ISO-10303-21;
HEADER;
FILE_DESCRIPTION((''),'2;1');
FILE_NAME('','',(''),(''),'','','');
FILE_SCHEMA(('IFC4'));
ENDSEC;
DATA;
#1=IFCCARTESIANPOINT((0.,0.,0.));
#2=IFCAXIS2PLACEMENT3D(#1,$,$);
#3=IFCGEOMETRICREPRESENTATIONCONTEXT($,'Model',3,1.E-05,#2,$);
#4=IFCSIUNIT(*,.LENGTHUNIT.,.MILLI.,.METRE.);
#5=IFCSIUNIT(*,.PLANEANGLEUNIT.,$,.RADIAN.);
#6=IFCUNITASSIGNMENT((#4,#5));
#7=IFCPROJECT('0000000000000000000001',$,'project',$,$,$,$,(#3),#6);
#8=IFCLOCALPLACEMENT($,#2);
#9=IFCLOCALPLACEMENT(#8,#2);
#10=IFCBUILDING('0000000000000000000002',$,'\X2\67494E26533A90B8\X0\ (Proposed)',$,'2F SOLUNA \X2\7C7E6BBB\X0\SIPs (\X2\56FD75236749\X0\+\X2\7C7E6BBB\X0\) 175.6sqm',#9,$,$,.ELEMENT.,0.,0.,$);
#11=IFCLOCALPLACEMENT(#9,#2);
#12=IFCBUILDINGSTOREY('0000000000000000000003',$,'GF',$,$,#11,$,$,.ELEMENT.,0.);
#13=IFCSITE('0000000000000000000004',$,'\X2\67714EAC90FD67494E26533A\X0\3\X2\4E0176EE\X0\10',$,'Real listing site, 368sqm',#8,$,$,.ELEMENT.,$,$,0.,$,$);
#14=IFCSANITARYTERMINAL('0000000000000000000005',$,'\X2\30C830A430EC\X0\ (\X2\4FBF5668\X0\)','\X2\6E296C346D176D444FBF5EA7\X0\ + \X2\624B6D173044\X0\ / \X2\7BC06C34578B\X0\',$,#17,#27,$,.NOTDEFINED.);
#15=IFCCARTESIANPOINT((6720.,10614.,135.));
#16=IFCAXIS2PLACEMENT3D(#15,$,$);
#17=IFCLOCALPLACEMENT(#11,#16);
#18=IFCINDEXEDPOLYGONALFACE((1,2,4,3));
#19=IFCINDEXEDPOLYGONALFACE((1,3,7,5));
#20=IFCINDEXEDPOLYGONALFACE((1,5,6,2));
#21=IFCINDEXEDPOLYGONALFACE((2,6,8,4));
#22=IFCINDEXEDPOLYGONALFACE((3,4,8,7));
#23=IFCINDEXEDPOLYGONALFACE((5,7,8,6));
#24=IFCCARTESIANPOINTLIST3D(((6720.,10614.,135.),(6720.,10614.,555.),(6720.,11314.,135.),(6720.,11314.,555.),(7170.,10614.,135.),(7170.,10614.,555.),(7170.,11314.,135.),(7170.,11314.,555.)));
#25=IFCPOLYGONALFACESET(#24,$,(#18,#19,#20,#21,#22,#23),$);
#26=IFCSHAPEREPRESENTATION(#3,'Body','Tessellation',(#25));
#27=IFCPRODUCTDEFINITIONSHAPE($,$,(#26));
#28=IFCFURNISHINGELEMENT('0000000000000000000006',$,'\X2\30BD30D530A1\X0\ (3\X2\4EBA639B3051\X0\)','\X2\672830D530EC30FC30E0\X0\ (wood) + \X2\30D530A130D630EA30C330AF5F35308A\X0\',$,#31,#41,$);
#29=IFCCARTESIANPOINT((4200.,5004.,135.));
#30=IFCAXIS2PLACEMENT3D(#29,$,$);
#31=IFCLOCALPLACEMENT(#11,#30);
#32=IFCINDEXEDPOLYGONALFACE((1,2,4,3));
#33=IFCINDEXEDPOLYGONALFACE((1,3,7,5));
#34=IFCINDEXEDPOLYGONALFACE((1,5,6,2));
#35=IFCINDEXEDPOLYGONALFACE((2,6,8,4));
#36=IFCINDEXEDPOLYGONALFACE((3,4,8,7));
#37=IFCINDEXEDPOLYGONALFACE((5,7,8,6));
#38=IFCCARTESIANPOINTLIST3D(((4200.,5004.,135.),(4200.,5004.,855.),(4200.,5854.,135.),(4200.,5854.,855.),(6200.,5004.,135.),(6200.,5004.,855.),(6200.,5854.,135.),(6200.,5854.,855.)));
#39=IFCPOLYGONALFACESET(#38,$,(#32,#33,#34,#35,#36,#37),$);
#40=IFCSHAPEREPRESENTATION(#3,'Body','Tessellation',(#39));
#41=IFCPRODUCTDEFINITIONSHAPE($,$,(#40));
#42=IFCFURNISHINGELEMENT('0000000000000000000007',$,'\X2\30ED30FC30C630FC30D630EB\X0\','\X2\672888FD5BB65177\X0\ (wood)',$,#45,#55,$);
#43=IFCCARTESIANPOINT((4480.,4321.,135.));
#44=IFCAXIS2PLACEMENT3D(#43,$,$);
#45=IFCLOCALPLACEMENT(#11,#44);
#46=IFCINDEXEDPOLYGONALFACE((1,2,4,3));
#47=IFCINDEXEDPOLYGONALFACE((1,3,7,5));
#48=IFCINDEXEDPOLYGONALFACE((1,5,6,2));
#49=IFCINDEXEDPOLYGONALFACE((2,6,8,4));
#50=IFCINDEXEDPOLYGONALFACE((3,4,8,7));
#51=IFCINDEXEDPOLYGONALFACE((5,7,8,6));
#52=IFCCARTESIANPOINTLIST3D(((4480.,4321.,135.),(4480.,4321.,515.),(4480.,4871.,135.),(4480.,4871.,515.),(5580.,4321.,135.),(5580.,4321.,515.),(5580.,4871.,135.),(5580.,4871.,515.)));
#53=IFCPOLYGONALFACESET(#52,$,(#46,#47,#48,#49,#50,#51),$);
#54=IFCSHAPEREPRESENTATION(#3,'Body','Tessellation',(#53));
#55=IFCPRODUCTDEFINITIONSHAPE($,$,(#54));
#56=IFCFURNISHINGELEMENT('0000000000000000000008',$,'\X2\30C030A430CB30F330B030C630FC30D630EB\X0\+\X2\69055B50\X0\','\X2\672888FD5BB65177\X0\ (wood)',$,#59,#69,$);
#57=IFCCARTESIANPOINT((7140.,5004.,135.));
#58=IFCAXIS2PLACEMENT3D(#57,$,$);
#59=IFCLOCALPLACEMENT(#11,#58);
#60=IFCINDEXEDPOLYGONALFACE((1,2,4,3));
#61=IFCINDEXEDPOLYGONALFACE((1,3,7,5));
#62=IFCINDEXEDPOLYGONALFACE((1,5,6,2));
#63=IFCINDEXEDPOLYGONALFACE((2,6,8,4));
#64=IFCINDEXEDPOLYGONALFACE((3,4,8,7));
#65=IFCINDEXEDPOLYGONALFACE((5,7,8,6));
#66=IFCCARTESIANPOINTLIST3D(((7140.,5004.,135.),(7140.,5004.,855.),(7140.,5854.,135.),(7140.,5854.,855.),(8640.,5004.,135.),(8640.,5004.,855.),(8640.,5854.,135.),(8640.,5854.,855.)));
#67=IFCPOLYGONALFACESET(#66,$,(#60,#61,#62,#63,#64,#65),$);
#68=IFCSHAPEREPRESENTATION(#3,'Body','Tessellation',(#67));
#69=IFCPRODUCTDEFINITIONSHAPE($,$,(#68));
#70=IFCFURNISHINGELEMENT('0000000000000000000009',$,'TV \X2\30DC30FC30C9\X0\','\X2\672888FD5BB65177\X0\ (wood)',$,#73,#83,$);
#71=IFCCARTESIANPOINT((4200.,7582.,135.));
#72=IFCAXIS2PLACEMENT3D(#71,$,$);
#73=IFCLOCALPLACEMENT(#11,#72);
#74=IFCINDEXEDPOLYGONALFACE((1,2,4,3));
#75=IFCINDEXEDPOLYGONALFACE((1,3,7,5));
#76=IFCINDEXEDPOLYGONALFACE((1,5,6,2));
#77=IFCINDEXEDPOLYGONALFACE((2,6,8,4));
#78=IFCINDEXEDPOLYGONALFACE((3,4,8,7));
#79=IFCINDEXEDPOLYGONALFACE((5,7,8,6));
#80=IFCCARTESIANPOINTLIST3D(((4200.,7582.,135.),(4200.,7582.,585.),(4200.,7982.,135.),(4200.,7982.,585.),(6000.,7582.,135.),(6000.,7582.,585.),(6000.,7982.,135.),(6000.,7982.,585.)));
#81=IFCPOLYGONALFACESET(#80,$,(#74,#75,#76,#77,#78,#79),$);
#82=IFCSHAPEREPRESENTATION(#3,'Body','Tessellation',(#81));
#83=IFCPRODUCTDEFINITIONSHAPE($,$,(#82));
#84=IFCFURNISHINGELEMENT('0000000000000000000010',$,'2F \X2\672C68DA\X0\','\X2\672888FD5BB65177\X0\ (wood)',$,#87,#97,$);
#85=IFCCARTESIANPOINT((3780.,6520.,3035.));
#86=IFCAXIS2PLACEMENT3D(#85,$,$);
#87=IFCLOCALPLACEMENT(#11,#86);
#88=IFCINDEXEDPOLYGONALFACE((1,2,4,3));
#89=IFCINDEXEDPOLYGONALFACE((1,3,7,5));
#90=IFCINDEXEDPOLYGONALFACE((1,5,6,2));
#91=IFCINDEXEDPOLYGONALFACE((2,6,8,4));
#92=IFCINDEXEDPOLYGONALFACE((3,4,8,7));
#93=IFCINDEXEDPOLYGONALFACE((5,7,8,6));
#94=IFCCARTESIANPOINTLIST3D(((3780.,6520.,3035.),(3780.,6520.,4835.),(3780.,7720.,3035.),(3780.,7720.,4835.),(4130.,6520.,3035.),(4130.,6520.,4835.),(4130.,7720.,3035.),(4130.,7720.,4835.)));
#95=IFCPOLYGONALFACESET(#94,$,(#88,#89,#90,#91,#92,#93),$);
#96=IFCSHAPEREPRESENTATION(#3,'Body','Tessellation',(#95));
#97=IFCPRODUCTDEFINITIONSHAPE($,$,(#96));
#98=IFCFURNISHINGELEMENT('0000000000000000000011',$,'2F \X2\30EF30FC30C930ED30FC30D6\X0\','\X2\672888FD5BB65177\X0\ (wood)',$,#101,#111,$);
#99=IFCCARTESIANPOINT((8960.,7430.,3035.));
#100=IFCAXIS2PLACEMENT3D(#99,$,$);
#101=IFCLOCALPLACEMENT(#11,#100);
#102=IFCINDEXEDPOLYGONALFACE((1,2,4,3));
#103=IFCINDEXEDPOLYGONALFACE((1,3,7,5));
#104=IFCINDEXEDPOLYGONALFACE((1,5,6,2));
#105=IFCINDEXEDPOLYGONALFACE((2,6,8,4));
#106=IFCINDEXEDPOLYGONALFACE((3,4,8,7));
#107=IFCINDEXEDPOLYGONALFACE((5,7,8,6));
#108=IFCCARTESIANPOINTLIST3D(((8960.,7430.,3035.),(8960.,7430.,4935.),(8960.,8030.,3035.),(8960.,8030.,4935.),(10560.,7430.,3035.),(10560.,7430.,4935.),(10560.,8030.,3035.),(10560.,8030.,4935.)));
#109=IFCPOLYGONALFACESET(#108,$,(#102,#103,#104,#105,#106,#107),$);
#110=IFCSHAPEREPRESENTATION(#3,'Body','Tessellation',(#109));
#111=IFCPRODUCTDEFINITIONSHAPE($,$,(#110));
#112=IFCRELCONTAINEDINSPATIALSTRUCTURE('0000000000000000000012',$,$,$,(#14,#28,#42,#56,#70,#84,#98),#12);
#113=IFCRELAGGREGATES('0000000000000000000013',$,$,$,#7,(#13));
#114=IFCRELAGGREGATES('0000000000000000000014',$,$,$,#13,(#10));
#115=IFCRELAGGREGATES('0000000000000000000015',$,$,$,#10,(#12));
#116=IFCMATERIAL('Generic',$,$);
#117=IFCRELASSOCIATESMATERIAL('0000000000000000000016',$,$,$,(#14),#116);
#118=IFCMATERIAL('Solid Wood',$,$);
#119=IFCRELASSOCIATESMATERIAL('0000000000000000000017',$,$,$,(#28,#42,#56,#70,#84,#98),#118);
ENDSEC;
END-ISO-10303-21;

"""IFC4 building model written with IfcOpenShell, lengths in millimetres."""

from ifc_helpers import new_model, si_unit, frame, frame_2d, origin, place, context, project, spatial, rectangle, extrude, material, element, save


model = new_model("IFC4")

# Units and contexts
model_context = context("Model", 3, precision=1e-05, world=origin())
ifc_project = project(units=[si_unit("LENGTHUNIT", "METRE", prefix="MILLI"), si_unit("PLANEANGLEUNIT", "RADIAN")], contexts=[model_context])

# Site, building, storey
site_placement = place(None, origin())
site = spatial("IfcSite", under=ifc_project, at=site_placement, Name="東京都杉並区3丁目10", ObjectType="Real listing site, 368sqm", CompositionType="ELEMENT", RefElevation=0.0)
building_placement = place(site_placement, origin())
building = spatial("IfcBuilding", under=site, at=building_placement, Name="杉並区邸 (Proposed)", ObjectType="2F SOLUNA 籾殻SIPs (国産杉+籾殻) 175.6sqm", CompositionType="ELEMENT", ElevationOfRefHeight=0.0, ElevationOfTerrain=0.0)
storey_placement = place(building_placement, origin())
storey = spatial("IfcBuildingStorey", under=building, at=storey_placement, Name="GF", CompositionType="ELEMENT", Elevation=0.0)

# Shared definitions
ifc_material_1 = material(Name="Generic")

# Shared definitions
ifc_material_2 = material(Name="Solid Wood")

# Sanitary terminal
sanitary_terminal_1_placement = place(storey_placement, frame((6720.0, 10614.0, 135.0)))
element("IfcSanitaryTerminal", 1, at=sanitary_terminal_1_placement, inside=storey, material=ifc_material_1, Name="トイレ (便器)", Description="温水洗浄便座 + 手洗い / 節水型", PredefinedType="NOTDEFINED", context=model_context, shape_type="SweptSolid", body=[
    extrude(rectangle(XDim=450.0, YDim=700.0, at=frame_2d((225.0, 350.0))), frame((6720.0, 10614.0, 135.0)), (0.0, 0.0, 1.0), 420.0),
])

# Furnishing elements
furnishing_1_placement = place(storey_placement, frame((4200.0, 5004.0, 135.0)))
element("IfcFurnishingElement", 2, at=furnishing_1_placement, inside=storey, material=ifc_material_2, Name="ソファ (3人掛け)", Description="木フレーム (wood) + ファブリック張り", context=model_context, shape_type="SweptSolid", body=[
    extrude(rectangle(XDim=2000.0, YDim=850.0, at=frame_2d((1000.0, 425.0))), frame((4200.0, 5004.0, 135.0)), (0.0, 0.0, 1.0), 720.0),
])
furnishing_2_placement = place(storey_placement, frame((4480.0, 4321.0, 135.0)))
element("IfcFurnishingElement", 3, at=furnishing_2_placement, inside=storey, material=ifc_material_2, Name="ローテーブル", Description="木製家具 (wood)", context=model_context, shape_type="SweptSolid", body=[
    extrude(rectangle(XDim=1100.0, YDim=550.0, at=frame_2d((550.0, 275.0))), frame((4480.0, 4321.0, 135.0)), (0.0, 0.0, 1.0), 380.0),
])
furnishing_3_placement = place(storey_placement, frame((7140.0, 5004.0, 135.0)))
element("IfcFurnishingElement", 4, at=furnishing_3_placement, inside=storey, material=ifc_material_2, Name="ダイニングテーブル+椅子", Description="木製家具 (wood)", context=model_context, shape_type="SweptSolid", body=[
    extrude(rectangle(XDim=1500.0, YDim=850.0, at=frame_2d((750.0, 425.0))), frame((7140.0, 5004.0, 135.0)), (0.0, 0.0, 1.0), 720.0),
])
furnishing_4_placement = place(storey_placement, frame((4200.0, 7582.0, 135.0)))
element("IfcFurnishingElement", 5, at=furnishing_4_placement, inside=storey, material=ifc_material_2, Name="TV ボード", Description="木製家具 (wood)", context=model_context, shape_type="SweptSolid", body=[
    extrude(rectangle(XDim=1800.0, YDim=400.0, at=frame_2d((900.0, 200.0))), frame((4200.0, 7582.0, 135.0)), (0.0, 0.0, 1.0), 450.0),
])
furnishing_5_placement = place(storey_placement, frame((3780.0, 6520.0, 3035.0)))
element("IfcFurnishingElement", 6, at=furnishing_5_placement, inside=storey, material=ifc_material_2, Name="2F 本棚", Description="木製家具 (wood)", context=model_context, shape_type="SweptSolid", body=[
    extrude(rectangle(XDim=350.0, YDim=1200.0, at=frame_2d((175.0, 600.0))), frame((3780.0, 6520.0, 3035.0)), (0.0, 0.0, 1.0), 1800.0),
])
furnishing_6_placement = place(storey_placement, frame((8960.0, 7430.0, 3035.0)))
element("IfcFurnishingElement", 7, at=furnishing_6_placement, inside=storey, material=ifc_material_2, Name="2F ワードローブ", Description="木製家具 (wood)", context=model_context, shape_type="SweptSolid", body=[
    extrude(rectangle(XDim=1600.0, YDim=600.0, at=frame_2d((800.0, 300.0))), frame((8960.0, 7430.0, 3035.0)), (0.0, 0.0, 1.0), 1900.0),
])

save(model, "model.ifc")
